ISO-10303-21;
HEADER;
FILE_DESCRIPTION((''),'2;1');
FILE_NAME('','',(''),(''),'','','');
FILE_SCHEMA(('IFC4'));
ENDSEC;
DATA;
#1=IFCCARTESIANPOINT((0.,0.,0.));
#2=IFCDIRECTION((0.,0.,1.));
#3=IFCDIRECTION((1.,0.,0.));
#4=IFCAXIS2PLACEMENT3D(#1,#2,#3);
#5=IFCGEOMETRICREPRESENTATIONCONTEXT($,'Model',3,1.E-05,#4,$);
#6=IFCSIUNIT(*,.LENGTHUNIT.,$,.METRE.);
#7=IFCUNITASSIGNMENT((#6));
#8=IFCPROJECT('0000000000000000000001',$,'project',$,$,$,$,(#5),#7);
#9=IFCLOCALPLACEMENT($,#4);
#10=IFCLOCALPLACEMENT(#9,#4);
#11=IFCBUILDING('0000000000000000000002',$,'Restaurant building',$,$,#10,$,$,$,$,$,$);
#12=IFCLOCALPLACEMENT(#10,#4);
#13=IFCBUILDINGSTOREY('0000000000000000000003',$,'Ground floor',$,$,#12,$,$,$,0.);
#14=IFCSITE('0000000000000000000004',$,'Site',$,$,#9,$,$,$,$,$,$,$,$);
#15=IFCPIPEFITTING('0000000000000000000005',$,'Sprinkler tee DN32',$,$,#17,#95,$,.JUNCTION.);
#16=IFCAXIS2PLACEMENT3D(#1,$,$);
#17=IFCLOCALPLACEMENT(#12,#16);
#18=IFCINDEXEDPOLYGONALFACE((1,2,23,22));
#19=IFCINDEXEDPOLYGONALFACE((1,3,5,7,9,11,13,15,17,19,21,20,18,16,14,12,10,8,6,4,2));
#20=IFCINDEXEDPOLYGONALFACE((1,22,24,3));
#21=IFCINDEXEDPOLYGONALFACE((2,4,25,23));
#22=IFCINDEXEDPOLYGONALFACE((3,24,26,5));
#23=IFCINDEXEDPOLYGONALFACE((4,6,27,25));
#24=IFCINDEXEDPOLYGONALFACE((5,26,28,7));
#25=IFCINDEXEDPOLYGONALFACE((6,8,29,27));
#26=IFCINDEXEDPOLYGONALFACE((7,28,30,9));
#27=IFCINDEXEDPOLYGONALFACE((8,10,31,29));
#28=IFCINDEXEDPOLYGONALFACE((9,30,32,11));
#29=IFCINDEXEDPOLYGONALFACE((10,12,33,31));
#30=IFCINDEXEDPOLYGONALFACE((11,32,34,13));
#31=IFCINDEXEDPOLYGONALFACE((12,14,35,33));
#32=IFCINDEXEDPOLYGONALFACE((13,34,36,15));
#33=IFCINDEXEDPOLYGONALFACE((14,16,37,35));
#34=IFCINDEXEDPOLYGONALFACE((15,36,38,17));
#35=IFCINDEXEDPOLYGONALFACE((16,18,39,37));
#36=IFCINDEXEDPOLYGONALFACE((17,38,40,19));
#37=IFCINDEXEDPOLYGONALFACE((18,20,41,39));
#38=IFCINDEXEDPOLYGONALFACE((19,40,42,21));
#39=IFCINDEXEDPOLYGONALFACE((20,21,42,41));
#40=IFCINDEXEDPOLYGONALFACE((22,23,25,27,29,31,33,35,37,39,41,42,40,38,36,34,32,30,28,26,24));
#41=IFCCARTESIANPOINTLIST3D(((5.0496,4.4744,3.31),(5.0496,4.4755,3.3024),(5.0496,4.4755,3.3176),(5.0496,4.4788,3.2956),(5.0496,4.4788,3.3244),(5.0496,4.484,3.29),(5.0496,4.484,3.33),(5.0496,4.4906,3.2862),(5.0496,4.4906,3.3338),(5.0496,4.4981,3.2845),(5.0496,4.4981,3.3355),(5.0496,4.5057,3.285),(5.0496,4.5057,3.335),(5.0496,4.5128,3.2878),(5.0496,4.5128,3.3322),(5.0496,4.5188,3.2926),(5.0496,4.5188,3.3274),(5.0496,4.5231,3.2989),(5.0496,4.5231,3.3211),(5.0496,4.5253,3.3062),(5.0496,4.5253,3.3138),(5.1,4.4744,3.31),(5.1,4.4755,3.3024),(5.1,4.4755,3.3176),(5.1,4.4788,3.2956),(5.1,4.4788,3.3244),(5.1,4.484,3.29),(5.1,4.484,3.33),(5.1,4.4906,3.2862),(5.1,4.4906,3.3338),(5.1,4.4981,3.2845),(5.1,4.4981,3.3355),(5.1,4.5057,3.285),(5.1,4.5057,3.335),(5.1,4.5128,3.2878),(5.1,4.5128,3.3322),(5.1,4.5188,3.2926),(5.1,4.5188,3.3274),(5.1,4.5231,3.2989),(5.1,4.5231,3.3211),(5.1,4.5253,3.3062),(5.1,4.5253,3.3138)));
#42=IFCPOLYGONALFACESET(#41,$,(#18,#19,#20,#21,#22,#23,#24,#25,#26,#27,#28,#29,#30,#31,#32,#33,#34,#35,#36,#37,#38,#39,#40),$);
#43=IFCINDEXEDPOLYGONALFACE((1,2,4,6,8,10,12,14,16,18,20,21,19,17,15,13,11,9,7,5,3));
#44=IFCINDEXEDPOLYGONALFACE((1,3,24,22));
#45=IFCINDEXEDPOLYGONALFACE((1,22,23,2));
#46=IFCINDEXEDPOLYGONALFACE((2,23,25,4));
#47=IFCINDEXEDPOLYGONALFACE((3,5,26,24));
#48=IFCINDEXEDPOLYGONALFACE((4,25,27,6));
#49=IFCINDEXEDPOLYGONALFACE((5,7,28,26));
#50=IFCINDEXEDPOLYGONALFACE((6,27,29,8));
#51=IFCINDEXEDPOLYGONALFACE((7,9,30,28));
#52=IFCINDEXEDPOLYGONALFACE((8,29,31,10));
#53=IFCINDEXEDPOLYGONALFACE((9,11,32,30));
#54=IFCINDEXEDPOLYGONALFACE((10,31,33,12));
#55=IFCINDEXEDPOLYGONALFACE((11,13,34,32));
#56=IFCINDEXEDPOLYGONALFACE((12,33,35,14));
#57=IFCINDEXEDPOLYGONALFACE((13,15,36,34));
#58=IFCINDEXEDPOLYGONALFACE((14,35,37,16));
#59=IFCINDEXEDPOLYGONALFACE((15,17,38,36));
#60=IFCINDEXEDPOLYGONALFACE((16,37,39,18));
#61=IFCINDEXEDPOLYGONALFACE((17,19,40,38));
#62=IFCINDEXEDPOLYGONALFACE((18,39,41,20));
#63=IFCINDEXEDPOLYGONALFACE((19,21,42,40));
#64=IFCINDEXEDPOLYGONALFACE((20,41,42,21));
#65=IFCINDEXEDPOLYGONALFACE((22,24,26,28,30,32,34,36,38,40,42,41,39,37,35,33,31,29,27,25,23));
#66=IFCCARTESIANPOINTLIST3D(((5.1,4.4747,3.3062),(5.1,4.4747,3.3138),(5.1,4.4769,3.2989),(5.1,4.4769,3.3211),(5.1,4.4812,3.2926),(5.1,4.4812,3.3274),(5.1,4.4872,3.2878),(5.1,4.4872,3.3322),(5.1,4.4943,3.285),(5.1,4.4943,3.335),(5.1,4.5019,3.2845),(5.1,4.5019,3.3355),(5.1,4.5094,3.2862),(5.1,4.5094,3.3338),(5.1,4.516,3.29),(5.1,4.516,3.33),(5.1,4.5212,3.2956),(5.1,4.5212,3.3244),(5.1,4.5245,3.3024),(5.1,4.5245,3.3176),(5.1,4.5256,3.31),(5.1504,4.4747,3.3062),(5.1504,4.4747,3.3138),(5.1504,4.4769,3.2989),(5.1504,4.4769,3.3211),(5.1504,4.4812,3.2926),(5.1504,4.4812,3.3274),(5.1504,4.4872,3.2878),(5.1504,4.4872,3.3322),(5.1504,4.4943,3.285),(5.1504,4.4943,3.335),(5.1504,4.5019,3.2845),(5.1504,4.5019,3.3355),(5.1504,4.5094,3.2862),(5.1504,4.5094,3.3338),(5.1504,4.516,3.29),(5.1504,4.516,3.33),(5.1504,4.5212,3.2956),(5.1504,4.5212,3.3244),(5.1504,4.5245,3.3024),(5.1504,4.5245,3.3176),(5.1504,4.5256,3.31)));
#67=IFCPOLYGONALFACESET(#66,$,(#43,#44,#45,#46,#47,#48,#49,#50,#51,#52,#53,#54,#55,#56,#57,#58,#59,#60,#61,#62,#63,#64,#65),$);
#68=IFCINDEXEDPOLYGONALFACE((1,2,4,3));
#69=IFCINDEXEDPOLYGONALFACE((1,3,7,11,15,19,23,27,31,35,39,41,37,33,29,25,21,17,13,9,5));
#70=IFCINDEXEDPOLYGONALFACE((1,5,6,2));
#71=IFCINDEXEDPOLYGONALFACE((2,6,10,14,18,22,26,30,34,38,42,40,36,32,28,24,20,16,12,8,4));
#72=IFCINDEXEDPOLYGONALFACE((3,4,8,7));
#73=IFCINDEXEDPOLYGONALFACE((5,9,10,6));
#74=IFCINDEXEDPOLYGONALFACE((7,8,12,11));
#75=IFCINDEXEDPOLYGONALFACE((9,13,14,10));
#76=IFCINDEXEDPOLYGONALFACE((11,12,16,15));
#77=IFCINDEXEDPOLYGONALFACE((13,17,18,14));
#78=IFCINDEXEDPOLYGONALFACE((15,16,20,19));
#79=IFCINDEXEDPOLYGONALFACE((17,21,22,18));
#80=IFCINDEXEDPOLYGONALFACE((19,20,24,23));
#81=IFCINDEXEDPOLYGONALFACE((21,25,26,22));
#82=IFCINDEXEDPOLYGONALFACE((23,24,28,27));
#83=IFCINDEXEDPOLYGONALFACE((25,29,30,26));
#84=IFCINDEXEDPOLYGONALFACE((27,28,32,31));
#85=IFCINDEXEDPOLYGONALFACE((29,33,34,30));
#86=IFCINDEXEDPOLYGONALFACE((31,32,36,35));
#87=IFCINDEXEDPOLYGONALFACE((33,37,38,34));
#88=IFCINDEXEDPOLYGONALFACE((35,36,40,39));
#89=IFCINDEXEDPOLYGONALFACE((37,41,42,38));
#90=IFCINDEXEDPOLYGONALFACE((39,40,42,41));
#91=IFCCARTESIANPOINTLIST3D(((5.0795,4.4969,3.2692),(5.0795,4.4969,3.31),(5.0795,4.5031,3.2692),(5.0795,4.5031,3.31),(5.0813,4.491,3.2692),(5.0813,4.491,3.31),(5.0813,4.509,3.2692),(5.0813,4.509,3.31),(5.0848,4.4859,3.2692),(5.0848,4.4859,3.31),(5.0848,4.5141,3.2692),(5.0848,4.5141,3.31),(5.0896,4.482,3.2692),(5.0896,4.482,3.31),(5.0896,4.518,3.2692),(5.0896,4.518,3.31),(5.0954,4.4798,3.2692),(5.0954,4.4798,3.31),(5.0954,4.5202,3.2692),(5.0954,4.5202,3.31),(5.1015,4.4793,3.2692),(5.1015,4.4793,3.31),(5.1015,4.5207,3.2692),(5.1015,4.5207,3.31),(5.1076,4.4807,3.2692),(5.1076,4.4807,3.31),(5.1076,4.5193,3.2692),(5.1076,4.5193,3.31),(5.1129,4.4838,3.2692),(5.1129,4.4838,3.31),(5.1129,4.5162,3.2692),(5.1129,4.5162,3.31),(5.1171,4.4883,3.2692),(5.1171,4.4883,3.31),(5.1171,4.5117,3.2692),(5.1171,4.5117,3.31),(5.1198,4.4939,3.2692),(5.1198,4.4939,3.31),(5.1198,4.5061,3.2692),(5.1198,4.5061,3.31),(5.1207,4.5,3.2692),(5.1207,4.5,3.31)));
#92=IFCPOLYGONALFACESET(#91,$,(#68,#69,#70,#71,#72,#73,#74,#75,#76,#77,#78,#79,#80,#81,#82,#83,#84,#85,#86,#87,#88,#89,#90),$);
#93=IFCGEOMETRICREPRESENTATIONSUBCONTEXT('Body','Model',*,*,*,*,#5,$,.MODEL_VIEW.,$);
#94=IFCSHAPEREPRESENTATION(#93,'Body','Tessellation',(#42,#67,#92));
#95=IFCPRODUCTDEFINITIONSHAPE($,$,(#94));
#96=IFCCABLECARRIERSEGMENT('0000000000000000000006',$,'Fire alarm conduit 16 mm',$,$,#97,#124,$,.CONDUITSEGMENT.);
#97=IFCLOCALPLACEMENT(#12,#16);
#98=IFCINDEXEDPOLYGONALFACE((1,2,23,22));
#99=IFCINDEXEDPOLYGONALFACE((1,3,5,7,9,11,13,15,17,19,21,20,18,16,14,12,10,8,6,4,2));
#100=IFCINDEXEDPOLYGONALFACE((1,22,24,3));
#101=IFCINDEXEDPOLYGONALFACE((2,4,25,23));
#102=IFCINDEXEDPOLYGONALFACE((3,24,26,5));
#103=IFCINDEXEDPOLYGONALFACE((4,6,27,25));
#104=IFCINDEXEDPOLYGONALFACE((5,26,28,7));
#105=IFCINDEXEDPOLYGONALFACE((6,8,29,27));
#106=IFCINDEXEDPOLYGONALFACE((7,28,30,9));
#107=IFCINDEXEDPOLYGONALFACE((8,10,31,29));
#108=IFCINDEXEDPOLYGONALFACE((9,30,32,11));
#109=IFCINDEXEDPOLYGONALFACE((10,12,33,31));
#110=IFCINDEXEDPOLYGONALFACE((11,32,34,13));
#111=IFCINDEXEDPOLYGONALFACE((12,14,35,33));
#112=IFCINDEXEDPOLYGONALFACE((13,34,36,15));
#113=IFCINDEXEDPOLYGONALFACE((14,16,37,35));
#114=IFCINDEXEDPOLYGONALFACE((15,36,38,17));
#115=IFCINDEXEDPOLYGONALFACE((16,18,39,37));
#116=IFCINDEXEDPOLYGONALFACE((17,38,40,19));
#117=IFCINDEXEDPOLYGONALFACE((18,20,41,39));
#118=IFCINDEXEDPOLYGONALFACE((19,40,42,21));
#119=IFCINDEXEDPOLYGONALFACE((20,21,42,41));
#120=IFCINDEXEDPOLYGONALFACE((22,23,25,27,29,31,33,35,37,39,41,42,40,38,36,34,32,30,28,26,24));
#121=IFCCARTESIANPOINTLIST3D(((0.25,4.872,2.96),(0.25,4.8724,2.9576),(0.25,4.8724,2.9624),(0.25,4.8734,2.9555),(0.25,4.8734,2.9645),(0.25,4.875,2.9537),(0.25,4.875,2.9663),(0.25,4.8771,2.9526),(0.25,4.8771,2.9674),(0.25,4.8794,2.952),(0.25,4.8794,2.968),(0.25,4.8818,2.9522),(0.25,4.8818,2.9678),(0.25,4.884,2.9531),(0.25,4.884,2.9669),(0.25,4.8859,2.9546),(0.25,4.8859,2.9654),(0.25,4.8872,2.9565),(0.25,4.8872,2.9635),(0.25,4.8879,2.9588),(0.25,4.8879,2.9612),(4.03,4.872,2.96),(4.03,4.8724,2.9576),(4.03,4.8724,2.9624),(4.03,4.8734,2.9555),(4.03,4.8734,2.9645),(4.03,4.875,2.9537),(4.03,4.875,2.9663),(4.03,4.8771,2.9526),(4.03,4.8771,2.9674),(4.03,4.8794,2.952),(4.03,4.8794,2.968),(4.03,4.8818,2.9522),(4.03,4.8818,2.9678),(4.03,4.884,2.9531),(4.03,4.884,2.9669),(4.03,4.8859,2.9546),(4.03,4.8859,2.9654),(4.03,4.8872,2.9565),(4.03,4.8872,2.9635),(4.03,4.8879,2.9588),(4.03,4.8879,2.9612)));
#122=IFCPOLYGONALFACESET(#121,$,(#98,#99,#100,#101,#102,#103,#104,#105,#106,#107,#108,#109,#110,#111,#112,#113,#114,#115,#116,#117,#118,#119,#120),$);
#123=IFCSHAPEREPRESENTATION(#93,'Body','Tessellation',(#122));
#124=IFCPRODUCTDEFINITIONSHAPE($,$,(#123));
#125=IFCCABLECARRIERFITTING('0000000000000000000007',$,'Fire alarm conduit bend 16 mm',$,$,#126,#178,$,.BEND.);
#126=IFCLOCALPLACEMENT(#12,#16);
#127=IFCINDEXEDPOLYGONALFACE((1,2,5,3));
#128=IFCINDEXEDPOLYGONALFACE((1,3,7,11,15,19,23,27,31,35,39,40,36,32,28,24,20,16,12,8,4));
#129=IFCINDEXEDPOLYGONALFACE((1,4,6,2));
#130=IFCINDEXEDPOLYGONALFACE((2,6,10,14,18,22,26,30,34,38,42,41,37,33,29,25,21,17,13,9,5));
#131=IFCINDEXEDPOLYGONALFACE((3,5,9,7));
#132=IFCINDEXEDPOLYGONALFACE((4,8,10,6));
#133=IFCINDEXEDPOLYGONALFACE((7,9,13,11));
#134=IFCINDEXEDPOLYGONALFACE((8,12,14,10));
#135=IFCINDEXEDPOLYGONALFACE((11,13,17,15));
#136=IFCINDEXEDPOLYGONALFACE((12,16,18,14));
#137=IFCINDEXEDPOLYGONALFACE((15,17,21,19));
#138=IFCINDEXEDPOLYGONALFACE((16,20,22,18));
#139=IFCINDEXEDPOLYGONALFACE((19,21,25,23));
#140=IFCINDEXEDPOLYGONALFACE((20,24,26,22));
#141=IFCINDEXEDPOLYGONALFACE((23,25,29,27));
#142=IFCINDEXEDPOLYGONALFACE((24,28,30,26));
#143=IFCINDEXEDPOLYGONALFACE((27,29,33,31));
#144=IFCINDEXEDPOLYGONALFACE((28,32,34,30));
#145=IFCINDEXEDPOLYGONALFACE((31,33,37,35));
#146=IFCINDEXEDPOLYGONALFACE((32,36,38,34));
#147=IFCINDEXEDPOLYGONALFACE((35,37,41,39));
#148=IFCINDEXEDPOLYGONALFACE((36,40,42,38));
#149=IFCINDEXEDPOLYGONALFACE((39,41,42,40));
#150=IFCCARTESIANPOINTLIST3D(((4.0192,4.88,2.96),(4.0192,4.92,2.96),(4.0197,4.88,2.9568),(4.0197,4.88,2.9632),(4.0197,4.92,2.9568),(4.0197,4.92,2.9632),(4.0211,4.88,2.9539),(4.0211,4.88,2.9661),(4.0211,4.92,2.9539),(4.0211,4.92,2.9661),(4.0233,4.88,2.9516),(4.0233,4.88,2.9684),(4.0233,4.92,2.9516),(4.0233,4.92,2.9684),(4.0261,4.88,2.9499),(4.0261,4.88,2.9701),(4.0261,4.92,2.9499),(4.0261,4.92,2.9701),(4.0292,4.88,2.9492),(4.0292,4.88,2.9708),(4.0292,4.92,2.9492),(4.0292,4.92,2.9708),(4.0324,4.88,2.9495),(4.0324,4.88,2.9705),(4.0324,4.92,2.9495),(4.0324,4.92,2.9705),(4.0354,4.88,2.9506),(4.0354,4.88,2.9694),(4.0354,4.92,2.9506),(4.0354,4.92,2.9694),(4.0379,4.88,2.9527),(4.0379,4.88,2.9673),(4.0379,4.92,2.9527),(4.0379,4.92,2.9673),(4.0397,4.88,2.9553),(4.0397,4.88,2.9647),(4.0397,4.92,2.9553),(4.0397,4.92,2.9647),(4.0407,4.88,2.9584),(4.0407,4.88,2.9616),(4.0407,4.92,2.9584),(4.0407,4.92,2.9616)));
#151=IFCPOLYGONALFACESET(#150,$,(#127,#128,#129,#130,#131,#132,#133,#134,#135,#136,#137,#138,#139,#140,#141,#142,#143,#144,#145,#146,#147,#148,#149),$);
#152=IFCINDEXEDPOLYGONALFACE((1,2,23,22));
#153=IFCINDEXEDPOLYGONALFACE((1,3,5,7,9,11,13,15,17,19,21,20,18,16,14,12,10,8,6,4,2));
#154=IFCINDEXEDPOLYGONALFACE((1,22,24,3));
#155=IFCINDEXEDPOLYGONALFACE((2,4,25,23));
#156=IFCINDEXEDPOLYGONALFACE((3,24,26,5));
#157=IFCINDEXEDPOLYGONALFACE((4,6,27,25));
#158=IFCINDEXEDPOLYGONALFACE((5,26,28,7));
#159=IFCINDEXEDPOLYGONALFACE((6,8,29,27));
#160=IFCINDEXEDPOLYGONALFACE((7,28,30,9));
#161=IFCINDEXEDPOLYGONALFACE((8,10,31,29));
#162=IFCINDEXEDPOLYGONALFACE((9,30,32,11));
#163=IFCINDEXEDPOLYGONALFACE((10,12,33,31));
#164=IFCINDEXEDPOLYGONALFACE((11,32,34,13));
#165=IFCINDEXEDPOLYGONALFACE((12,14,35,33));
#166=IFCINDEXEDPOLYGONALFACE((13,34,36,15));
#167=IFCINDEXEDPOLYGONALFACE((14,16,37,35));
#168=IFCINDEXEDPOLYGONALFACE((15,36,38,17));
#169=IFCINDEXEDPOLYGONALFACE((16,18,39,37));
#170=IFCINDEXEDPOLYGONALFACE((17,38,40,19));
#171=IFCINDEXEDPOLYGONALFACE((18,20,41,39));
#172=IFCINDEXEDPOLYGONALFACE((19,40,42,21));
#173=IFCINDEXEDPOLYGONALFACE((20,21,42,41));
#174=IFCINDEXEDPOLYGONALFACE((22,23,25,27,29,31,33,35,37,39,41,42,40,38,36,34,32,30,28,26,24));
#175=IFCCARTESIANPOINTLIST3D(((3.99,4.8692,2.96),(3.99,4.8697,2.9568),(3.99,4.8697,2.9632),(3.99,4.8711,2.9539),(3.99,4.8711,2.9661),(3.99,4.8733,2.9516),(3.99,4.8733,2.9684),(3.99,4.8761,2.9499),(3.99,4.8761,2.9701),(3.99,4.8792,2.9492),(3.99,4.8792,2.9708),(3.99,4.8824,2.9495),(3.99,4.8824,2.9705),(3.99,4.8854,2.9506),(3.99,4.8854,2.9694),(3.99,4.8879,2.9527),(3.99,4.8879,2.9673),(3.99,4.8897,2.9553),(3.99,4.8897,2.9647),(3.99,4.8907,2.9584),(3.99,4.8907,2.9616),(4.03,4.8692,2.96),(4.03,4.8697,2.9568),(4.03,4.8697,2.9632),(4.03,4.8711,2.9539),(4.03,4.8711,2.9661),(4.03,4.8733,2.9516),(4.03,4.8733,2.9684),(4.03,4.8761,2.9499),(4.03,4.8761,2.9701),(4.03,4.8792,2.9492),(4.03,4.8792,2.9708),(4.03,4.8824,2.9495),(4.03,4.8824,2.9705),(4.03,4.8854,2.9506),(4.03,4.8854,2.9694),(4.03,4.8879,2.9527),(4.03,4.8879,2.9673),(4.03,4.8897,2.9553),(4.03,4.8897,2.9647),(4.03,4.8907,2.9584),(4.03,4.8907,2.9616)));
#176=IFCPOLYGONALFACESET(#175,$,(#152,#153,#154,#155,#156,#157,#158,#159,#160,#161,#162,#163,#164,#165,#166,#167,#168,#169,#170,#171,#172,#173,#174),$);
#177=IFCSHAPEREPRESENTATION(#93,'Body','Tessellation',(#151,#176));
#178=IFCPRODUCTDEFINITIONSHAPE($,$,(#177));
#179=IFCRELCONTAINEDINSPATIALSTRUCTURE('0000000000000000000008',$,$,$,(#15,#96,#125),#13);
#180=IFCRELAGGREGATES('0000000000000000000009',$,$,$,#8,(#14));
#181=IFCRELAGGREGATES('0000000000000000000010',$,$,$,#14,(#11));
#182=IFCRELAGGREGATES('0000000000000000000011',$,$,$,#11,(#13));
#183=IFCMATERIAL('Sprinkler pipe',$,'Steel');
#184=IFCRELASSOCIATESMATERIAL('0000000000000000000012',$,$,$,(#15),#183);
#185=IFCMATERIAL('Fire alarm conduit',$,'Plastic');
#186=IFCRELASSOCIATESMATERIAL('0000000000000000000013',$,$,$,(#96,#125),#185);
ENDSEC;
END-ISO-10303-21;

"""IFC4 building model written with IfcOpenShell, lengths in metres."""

from ifc_helpers import new_model, si_unit, frame, origin_with_axes, origin_2d, place, context, subcontext, project, spatial, circle, extrude, material, element, save


model = new_model("IFC4")

# Units and contexts
model_context = context("Model", 3, precision=1e-05, world=origin_with_axes())
body_context = subcontext(model_context, "Body", "Model", "MODEL_VIEW")
ifc_project = project(units=[si_unit("LENGTHUNIT", "METRE")], contexts=[model_context])

# Site, building, storey
site_placement = place(None, origin_with_axes())
site = spatial("IfcSite", under=ifc_project, at=site_placement, Name="Site")
building_placement = place(site_placement, origin_with_axes())
building = spatial("IfcBuilding", under=site, at=building_placement, Name="Restaurant building")
storey_placement = place(building_placement, origin_with_axes())
storey = spatial("IfcBuildingStorey", under=building, at=storey_placement, Name="Ground floor", Elevation=0.0)

# Shared definitions
ifc_material_1 = material(Name="Sprinkler pipe", Category="Steel")

# Pipe fitting
pipe_fitting_placement = place(storey_placement, frame((5.1, 4.5, 3.31)))
element("IfcPipeFitting", 1, at=pipe_fitting_placement, inside=storey, material=ifc_material_1, Name="Sprinkler tee DN32", PredefinedType="JUNCTION", context=body_context, shape_type="SweptSolid", body=[
    extrude(circle(Radius=0.0256, at=origin_2d()), frame((0.0, 0.0, 0.0), z_axis=(-1.0, 0.0, 0.0), x_axis=(0.0, -1.0, 0.0)), (0.0, 0.0, 1.0), 0.0504),
    extrude(circle(Radius=0.0256, at=origin_2d()), frame((0.0, 0.0, 0.0), z_axis=(1.0, 0.0, 0.0), x_axis=(0.0, 1.0, 0.0)), (0.0, 0.0, 1.0), 0.0504),
    extrude(circle(Radius=0.0207, at=origin_2d()), frame((0.0, 0.0, 0.0), z_axis=(0.0, 0.0, -1.0), x_axis=(1.0, 0.0, 0.0)), (0.0, 0.0, 1.0), 0.0408),
])

# Cable carrier segment
ifc_material_2 = material(Name="Fire alarm conduit", Category="Plastic")
cable_carrier_segment_1_placement = place(storey_placement, frame((4.03, 4.88, 2.96)))
element("IfcCableCarrierSegment", 2, at=cable_carrier_segment_1_placement, inside=storey, material=ifc_material_2, Name="Fire alarm conduit 16 mm", PredefinedType="CONDUITSEGMENT", context=body_context, shape_type="SweptSolid", body=[
    extrude(circle(Radius=0.008, at=origin_2d()), frame((0.0, 0.0, 0.0), z_axis=(-1.0, 0.0, 0.0), x_axis=(0.0, -1.0, 0.0)), (0.0, 0.0, 1.0), 3.78),
])

# Cable carrier fitting
cable_carrier_fitting_1_placement = place(storey_placement, frame((4.03, 4.88, 2.96)))
element("IfcCableCarrierFitting", 3, at=cable_carrier_fitting_1_placement, inside=storey, material=ifc_material_2, Name="Fire alarm conduit bend 16 mm", PredefinedType="BEND", context=body_context, shape_type="SweptSolid", body=[
    extrude(circle(Radius=0.0108, at=origin_2d()), frame((0.0, 0.0, 0.0), z_axis=(0.0, 1.0, 0.0), x_axis=(-1.0, 0.0, 0.0)), (0.0, 0.0, 1.0), 0.04),
    extrude(circle(Radius=0.0108, at=origin_2d()), frame((0.0, 0.0, 0.0), z_axis=(-1.0, 0.0, 0.0), x_axis=(0.0, -1.0, 0.0)), (0.0, 0.0, 1.0), 0.04),
])

save(model, "model.ifc")
